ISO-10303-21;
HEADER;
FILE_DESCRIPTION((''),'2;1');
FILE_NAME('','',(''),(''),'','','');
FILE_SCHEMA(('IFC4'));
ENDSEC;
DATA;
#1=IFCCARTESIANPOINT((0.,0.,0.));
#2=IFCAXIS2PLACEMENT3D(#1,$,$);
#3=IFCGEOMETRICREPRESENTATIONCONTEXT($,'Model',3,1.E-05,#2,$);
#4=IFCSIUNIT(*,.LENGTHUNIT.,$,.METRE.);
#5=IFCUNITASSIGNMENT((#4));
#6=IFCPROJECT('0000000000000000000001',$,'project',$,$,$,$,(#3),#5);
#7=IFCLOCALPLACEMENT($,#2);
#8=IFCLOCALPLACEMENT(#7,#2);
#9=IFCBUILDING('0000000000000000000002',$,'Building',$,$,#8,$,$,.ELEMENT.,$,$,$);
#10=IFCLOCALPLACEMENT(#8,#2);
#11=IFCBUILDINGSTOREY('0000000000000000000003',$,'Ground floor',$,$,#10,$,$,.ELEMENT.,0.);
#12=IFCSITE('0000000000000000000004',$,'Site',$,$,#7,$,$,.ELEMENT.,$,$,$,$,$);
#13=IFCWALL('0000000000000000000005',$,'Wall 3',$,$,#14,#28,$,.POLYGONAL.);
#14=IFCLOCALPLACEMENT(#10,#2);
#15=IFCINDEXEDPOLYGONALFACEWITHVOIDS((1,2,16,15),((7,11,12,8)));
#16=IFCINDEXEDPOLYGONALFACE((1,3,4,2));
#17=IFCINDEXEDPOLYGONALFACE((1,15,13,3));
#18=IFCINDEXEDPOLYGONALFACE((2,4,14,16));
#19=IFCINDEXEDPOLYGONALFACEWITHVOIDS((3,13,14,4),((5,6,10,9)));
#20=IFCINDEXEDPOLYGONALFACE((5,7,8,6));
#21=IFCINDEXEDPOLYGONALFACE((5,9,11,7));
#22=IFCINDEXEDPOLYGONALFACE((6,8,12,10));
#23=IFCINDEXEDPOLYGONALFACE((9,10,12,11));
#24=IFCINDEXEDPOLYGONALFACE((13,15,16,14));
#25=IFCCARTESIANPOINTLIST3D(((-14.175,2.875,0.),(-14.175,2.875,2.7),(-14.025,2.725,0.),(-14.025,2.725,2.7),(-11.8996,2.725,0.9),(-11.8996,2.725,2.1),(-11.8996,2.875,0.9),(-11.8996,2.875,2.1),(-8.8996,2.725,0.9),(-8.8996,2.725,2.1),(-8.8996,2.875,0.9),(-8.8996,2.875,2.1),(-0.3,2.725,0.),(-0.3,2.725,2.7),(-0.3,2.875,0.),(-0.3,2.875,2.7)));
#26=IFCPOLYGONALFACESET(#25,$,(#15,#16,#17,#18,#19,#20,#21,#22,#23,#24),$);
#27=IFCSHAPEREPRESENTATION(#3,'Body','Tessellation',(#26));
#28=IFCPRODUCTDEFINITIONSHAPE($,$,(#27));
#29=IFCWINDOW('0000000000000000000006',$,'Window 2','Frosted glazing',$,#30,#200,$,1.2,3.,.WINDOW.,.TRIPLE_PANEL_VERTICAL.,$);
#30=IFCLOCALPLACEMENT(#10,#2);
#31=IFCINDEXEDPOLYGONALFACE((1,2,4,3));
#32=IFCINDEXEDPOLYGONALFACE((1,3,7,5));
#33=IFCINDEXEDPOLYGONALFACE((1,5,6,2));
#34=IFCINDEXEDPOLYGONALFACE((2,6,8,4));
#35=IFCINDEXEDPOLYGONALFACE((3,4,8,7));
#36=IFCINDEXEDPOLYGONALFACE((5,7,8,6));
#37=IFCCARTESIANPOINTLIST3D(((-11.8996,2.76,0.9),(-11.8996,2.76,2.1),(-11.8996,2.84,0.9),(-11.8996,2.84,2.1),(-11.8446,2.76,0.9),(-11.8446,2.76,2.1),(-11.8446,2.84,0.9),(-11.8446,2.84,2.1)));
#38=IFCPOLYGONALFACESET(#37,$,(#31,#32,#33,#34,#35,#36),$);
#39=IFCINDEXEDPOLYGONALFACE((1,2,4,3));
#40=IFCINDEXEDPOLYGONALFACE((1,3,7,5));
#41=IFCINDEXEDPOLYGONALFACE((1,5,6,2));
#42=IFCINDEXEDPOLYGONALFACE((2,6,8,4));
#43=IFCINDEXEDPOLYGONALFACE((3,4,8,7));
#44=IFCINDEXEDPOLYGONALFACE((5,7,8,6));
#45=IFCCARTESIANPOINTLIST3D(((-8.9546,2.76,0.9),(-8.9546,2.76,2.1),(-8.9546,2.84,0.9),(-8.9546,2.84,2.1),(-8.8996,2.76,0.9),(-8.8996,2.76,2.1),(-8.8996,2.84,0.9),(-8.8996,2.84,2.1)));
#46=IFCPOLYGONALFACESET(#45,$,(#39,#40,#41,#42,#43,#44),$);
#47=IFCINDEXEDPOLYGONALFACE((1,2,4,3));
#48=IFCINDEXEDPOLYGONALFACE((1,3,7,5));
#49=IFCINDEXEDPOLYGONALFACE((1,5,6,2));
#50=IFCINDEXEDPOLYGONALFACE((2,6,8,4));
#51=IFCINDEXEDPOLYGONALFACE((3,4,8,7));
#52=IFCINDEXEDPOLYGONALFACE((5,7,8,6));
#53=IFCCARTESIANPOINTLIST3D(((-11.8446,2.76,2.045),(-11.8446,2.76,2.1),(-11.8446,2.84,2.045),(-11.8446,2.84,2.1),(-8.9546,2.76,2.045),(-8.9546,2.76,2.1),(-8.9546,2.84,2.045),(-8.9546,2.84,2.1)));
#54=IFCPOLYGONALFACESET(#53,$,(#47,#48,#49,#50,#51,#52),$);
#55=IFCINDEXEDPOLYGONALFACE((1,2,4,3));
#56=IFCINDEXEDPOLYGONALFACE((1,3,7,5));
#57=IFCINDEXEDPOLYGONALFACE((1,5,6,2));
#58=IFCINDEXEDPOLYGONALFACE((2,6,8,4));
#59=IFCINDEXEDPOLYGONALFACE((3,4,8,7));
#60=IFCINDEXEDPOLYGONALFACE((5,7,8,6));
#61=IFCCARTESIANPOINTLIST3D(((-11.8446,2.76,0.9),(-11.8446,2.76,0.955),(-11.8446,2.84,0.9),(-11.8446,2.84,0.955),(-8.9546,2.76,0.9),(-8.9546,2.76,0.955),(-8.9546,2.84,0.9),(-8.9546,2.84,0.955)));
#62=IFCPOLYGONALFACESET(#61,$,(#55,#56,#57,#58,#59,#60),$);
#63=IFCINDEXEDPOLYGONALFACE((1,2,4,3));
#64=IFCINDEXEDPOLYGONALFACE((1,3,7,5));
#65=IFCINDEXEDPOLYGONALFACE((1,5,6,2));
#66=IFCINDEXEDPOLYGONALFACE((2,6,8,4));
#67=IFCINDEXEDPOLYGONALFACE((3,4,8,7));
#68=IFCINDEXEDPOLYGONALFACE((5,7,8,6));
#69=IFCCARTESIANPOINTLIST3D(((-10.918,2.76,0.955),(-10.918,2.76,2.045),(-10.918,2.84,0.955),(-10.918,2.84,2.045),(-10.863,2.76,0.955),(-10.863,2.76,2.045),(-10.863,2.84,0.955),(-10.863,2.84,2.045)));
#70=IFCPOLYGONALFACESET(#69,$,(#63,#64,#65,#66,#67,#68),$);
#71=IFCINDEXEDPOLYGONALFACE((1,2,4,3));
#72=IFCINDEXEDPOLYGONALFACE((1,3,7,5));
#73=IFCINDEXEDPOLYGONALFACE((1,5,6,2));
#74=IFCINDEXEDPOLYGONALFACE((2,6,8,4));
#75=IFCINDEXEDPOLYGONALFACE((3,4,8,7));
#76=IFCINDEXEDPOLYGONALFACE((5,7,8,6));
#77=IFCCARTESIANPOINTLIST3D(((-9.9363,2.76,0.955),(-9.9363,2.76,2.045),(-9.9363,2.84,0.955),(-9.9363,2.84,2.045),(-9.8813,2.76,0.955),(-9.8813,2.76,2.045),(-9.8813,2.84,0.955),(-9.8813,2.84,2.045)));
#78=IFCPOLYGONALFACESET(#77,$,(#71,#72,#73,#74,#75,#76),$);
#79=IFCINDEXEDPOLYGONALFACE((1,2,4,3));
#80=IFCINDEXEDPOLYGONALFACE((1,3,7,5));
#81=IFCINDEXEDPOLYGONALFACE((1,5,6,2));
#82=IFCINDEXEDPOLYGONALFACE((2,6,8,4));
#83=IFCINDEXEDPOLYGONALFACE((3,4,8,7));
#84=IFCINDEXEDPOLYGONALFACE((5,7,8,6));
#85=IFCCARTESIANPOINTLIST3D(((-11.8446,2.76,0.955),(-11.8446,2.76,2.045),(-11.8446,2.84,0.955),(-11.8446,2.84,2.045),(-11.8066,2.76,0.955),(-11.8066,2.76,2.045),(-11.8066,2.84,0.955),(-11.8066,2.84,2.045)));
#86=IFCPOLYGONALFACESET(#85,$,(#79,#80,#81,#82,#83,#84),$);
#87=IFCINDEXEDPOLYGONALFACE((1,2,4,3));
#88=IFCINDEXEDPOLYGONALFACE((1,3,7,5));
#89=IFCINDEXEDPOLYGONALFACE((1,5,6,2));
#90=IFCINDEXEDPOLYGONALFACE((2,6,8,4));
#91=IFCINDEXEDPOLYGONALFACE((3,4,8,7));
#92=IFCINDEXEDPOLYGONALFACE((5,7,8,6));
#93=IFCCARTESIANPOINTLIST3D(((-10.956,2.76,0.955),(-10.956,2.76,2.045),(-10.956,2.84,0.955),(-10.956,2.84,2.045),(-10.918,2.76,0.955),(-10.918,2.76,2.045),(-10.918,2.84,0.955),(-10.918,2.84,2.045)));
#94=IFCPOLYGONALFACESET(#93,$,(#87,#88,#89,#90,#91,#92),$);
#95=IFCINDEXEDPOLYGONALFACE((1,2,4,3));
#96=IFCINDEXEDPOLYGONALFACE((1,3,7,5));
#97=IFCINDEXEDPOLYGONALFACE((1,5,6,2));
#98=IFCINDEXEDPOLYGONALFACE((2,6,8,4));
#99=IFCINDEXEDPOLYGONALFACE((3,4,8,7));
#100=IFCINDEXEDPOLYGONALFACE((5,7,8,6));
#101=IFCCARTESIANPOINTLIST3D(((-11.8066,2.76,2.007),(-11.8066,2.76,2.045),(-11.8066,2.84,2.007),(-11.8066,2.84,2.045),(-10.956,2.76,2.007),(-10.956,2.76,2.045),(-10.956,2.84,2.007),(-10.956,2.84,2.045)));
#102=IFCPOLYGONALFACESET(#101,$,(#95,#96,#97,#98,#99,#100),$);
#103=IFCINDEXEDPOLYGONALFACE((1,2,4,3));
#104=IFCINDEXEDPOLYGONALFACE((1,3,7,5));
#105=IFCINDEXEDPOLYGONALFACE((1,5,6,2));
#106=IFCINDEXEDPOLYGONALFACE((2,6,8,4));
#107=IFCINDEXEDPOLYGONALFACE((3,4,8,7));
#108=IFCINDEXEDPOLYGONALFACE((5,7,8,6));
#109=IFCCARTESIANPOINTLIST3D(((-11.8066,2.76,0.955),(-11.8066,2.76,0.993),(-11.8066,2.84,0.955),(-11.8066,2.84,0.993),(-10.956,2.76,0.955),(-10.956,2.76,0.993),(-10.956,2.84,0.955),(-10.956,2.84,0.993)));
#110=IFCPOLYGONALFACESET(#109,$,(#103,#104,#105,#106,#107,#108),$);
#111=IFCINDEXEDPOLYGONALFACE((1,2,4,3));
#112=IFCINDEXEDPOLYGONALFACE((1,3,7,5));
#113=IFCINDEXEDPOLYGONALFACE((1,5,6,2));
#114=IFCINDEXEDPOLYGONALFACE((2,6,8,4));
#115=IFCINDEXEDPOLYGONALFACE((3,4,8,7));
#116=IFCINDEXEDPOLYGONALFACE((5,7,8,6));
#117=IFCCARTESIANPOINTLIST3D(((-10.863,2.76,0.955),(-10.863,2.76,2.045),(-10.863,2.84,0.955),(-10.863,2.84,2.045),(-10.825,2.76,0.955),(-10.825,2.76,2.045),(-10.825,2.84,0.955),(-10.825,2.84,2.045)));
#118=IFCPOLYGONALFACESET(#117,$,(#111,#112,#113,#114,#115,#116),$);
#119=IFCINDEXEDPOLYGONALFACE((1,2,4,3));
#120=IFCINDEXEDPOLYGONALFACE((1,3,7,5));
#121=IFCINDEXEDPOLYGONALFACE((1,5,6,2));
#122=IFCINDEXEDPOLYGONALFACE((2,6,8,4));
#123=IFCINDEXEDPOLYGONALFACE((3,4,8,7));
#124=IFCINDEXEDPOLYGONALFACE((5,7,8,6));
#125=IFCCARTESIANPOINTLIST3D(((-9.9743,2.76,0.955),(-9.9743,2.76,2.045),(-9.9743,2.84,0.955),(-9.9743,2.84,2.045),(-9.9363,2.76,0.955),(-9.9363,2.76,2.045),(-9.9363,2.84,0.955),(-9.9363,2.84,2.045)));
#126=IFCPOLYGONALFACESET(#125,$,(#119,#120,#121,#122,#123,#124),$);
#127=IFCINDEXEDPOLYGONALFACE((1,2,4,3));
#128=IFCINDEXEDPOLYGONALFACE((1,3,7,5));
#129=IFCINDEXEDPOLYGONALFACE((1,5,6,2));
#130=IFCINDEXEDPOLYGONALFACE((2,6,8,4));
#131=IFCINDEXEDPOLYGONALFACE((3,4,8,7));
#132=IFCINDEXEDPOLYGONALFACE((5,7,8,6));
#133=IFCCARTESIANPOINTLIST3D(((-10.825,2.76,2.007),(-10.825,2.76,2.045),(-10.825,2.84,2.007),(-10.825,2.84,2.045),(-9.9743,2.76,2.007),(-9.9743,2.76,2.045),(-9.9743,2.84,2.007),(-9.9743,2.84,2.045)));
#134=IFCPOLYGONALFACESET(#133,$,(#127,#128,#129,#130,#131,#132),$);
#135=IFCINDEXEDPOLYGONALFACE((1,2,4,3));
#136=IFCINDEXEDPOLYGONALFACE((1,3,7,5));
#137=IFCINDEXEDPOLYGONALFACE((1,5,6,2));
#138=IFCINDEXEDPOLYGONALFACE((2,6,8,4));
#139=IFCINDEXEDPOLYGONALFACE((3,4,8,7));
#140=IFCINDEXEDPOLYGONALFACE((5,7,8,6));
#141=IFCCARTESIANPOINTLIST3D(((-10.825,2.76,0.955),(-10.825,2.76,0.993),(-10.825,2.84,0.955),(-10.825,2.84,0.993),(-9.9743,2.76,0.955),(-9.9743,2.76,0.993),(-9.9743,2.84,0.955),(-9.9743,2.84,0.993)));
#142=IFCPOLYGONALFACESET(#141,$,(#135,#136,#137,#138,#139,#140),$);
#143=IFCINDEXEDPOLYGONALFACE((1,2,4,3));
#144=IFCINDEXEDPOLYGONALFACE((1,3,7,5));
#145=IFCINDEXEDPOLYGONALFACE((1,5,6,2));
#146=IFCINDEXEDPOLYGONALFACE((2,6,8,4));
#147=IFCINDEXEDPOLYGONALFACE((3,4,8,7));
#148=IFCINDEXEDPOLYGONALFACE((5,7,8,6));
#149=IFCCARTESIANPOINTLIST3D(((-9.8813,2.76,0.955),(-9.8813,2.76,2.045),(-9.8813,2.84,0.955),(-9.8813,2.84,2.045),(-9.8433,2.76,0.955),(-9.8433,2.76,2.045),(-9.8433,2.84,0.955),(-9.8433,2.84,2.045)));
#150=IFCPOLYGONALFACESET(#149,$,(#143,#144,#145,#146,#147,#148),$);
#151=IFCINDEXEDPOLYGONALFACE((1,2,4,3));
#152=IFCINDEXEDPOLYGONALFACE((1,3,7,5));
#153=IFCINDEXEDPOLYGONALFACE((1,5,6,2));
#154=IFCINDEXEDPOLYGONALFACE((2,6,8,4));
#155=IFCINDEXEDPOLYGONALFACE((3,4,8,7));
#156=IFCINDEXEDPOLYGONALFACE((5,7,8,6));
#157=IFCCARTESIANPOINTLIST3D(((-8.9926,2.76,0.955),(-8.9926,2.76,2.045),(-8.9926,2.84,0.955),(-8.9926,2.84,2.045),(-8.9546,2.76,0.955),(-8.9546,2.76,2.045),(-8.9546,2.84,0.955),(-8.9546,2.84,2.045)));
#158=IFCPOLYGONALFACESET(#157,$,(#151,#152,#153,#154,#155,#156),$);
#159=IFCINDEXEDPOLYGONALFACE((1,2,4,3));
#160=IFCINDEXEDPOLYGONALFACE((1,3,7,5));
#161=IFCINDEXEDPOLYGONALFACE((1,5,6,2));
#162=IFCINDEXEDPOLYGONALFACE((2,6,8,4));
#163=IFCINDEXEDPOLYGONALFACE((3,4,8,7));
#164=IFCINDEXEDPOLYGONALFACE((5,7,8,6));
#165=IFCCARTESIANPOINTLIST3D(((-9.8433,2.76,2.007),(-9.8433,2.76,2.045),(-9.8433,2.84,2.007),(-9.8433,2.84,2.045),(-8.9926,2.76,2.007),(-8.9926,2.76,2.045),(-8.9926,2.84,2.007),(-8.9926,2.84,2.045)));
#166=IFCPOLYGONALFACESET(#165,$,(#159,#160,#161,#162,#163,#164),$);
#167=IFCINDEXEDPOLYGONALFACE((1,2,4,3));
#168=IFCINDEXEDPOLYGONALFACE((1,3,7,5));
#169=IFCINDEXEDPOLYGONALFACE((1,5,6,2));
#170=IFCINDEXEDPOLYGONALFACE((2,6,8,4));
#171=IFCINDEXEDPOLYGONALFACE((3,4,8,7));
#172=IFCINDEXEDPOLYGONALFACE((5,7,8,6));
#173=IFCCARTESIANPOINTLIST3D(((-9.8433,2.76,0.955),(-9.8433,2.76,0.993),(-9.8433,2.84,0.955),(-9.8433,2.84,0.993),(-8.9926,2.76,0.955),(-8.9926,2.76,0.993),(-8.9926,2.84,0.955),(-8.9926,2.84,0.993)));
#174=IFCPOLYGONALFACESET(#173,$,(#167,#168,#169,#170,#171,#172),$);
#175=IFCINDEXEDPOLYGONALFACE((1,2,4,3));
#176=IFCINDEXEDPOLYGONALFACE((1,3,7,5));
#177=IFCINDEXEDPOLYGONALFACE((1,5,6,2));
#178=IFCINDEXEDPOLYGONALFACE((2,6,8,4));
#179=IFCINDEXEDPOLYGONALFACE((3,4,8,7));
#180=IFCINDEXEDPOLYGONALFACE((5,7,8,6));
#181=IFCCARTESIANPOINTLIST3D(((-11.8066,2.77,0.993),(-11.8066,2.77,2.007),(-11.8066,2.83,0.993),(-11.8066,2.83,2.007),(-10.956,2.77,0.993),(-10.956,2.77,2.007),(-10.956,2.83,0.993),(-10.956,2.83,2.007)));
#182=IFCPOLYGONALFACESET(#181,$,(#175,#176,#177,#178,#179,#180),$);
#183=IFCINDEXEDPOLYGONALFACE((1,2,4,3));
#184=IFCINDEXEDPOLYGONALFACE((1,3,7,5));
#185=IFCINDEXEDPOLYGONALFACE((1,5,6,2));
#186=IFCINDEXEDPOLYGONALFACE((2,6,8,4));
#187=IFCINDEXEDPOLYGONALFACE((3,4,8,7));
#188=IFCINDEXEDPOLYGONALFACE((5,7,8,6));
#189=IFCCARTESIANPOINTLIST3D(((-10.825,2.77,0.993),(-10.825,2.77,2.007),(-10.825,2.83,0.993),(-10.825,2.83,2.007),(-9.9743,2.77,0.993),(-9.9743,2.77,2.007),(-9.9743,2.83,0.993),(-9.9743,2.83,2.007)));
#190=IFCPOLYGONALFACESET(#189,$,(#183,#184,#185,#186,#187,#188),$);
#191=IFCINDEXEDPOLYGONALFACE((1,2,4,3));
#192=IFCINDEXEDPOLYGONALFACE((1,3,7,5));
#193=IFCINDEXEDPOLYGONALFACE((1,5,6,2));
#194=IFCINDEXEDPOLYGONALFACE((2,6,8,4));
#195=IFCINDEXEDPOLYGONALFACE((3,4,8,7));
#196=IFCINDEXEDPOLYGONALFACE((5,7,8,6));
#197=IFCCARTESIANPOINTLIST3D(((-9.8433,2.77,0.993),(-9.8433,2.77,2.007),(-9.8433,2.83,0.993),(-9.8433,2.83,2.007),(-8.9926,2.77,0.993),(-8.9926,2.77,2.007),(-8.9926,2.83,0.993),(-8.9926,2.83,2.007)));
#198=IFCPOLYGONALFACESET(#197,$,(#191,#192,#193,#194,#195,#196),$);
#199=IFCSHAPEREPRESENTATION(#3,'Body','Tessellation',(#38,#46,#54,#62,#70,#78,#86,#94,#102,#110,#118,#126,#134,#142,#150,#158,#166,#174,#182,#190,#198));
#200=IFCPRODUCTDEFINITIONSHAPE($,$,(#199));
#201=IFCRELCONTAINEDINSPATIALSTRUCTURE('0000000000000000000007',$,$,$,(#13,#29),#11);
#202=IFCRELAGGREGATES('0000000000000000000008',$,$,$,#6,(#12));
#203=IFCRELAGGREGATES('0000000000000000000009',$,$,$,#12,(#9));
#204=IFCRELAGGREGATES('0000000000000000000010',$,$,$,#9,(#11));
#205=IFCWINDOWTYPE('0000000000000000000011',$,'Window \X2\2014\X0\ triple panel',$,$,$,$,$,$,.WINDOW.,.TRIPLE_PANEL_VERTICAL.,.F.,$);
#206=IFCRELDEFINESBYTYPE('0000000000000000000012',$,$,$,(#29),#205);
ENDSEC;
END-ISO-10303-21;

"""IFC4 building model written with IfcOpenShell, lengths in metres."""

from ifc_helpers import new_model, si_unit, frame, frame_2d, origin, origin_with_axes, place, context, project, spatial, polyline, rectangle, outline, extrude, type_object, element, fill, save


model = new_model("IFC4")

# Units and contexts
model_context = context("Model", 3, precision=1e-05, world=origin())
ifc_project = project(units=[si_unit("LENGTHUNIT", "METRE")], contexts=[model_context])

# Site, building, storey
site_placement = place(None, origin())
site = spatial("IfcSite", under=ifc_project, at=site_placement, Name="Site", CompositionType="ELEMENT")
building_placement = place(site_placement, origin())
building = spatial("IfcBuilding", under=site, at=building_placement, Name="Building", CompositionType="ELEMENT")
storey_placement = place(building_placement, origin())
storey = spatial("IfcBuildingStorey", under=building, at=storey_placement, Name="Ground floor", CompositionType="ELEMENT", Elevation=0.0)

# Wall, opening, window
wall_1_placement = place(storey_placement, origin_with_axes())
wall_1 = element("IfcWall", 1, at=wall_1_placement, inside=storey, Name="Wall 3", PredefinedType="POLYGONAL", context=model_context, shape_type="SweptSolid", body=[
    extrude(outline(polyline([(-14.175, 2.875), (-14.025, 2.725), (-0.3, 2.725), (-0.3, 2.875), (-14.175, 2.875)])), origin(), (0.0, 0.0, 1.0), 2.7),
])
opening_1_placement = place(storey_placement, frame((-11.8996, 2.8, 0.9), z_axis=(0.0, 0.0, 1.0), x_axis=(1.0, 0.0, 0.0)))
opening_1 = element("IfcOpeningElement", 2, at=opening_1_placement, cuts=wall_1, PredefinedType="OPENING", context=model_context, shape_type="SweptSolid", body=[
    extrude(rectangle(XDim=3.0, YDim=0.21, at=frame_2d((1.5, 0.0))), origin(), (0.0, 0.0, 1.0), 1.2),
])
window_type_1 = type_object("IfcWindowType", Name="Window — triple panel", ParameterTakesPrecedence=False, PartitioningType="TRIPLE_PANEL_VERTICAL", PredefinedType="WINDOW")
window_1_placement = place(storey_placement, frame((-11.8996, 2.8, 0.9), z_axis=(0.0, 0.0, 1.0), x_axis=(1.0, 0.0, 0.0)))
window_1 = element("IfcWindow", 3, at=window_1_placement, inside=storey, type_object=window_type_1, Name="Window 2", Description="Frosted glazing", OverallHeight=1.2, OverallWidth=3.0, PartitioningType="TRIPLE_PANEL_VERTICAL", PredefinedType="WINDOW", context=model_context, shape_type="SweptSolid", body=[
    extrude(rectangle(XDim=0.055, YDim=0.08, at=frame_2d((0.0275, 0.0))), origin(), (0.0, 0.0, 1.0), 1.2),
    extrude(rectangle(XDim=0.055, YDim=0.08, at=frame_2d((2.9725, 0.0))), origin(), (0.0, 0.0, 1.0), 1.2),
    extrude(rectangle(XDim=2.89, YDim=0.08, at=frame_2d((1.5, 0.0))), frame((0.0, 0.0, 1.145)), (0.0, 0.0, 1.0), 0.055),
    extrude(rectangle(XDim=2.89, YDim=0.08, at=frame_2d((1.5, 0.0))), origin(), (0.0, 0.0, 1.0), 0.055),
    extrude(rectangle(XDim=0.055, YDim=0.08, at=frame_2d((1.0092, 0.0))), frame((0.0, 0.0, 0.055)), (0.0, 0.0, 1.0), 1.09),
    extrude(rectangle(XDim=0.055, YDim=0.08, at=frame_2d((1.9908, 0.0))), frame((0.0, 0.0, 0.055)), (0.0, 0.0, 1.0), 1.09),
    extrude(rectangle(XDim=0.038, YDim=0.08, at=frame_2d((0.074, 0.0))), frame((0.0, 0.0, 0.055)), (0.0, 0.0, 1.0), 1.09),
    extrude(rectangle(XDim=0.038, YDim=0.08, at=frame_2d((0.9627, 0.0))), frame((0.0, 0.0, 0.055)), (0.0, 0.0, 1.0), 1.09),
    extrude(rectangle(XDim=0.8507, YDim=0.08, at=frame_2d((0.5183, 0.0))), frame((0.0, 0.0, 1.107)), (0.0, 0.0, 1.0), 0.038),
    extrude(rectangle(XDim=0.8507, YDim=0.08, at=frame_2d((0.5183, 0.0))), frame((0.0, 0.0, 0.055)), (0.0, 0.0, 1.0), 0.038),
    extrude(rectangle(XDim=0.038, YDim=0.08, at=frame_2d((1.0557, 0.0))), frame((0.0, 0.0, 0.055)), (0.0, 0.0, 1.0), 1.09),
    extrude(rectangle(XDim=0.038, YDim=0.08, at=frame_2d((1.9443, 0.0))), frame((0.0, 0.0, 0.055)), (0.0, 0.0, 1.0), 1.09),
    extrude(rectangle(XDim=0.8507, YDim=0.08, at=frame_2d((1.5, 0.0))), frame((0.0, 0.0, 1.107)), (0.0, 0.0, 1.0), 0.038),
    extrude(rectangle(XDim=0.8507, YDim=0.08, at=frame_2d((1.5, 0.0))), frame((0.0, 0.0, 0.055)), (0.0, 0.0, 1.0), 0.038),
    extrude(rectangle(XDim=0.038, YDim=0.08, at=frame_2d((2.0373, 0.0))), frame((0.0, 0.0, 0.055)), (0.0, 0.0, 1.0), 1.09),
    extrude(rectangle(XDim=0.038, YDim=0.08, at=frame_2d((2.926, 0.0))), frame((0.0, 0.0, 0.055)), (0.0, 0.0, 1.0), 1.09),
    extrude(rectangle(XDim=0.8507, YDim=0.08, at=frame_2d((2.4817, 0.0))), frame((0.0, 0.0, 1.107)), (0.0, 0.0, 1.0), 0.038),
    extrude(rectangle(XDim=0.8507, YDim=0.08, at=frame_2d((2.4817, 0.0))), frame((0.0, 0.0, 0.055)), (0.0, 0.0, 1.0), 0.038),
    extrude(rectangle(XDim=0.8507, YDim=0.06, at=frame_2d((0.5183, 0.0))), frame((0.0, 0.0, 0.093)), (0.0, 0.0, 1.0), 1.014),
    extrude(rectangle(XDim=0.8507, YDim=0.06, at=frame_2d((1.5, 0.0))), frame((0.0, 0.0, 0.093)), (0.0, 0.0, 1.0), 1.014),
    extrude(rectangle(XDim=0.8507, YDim=0.06, at=frame_2d((2.4817, 0.0))), frame((0.0, 0.0, 0.093)), (0.0, 0.0, 1.0), 1.014),
])
fill(opening_1, window_1)

save(model, "model.ifc")
